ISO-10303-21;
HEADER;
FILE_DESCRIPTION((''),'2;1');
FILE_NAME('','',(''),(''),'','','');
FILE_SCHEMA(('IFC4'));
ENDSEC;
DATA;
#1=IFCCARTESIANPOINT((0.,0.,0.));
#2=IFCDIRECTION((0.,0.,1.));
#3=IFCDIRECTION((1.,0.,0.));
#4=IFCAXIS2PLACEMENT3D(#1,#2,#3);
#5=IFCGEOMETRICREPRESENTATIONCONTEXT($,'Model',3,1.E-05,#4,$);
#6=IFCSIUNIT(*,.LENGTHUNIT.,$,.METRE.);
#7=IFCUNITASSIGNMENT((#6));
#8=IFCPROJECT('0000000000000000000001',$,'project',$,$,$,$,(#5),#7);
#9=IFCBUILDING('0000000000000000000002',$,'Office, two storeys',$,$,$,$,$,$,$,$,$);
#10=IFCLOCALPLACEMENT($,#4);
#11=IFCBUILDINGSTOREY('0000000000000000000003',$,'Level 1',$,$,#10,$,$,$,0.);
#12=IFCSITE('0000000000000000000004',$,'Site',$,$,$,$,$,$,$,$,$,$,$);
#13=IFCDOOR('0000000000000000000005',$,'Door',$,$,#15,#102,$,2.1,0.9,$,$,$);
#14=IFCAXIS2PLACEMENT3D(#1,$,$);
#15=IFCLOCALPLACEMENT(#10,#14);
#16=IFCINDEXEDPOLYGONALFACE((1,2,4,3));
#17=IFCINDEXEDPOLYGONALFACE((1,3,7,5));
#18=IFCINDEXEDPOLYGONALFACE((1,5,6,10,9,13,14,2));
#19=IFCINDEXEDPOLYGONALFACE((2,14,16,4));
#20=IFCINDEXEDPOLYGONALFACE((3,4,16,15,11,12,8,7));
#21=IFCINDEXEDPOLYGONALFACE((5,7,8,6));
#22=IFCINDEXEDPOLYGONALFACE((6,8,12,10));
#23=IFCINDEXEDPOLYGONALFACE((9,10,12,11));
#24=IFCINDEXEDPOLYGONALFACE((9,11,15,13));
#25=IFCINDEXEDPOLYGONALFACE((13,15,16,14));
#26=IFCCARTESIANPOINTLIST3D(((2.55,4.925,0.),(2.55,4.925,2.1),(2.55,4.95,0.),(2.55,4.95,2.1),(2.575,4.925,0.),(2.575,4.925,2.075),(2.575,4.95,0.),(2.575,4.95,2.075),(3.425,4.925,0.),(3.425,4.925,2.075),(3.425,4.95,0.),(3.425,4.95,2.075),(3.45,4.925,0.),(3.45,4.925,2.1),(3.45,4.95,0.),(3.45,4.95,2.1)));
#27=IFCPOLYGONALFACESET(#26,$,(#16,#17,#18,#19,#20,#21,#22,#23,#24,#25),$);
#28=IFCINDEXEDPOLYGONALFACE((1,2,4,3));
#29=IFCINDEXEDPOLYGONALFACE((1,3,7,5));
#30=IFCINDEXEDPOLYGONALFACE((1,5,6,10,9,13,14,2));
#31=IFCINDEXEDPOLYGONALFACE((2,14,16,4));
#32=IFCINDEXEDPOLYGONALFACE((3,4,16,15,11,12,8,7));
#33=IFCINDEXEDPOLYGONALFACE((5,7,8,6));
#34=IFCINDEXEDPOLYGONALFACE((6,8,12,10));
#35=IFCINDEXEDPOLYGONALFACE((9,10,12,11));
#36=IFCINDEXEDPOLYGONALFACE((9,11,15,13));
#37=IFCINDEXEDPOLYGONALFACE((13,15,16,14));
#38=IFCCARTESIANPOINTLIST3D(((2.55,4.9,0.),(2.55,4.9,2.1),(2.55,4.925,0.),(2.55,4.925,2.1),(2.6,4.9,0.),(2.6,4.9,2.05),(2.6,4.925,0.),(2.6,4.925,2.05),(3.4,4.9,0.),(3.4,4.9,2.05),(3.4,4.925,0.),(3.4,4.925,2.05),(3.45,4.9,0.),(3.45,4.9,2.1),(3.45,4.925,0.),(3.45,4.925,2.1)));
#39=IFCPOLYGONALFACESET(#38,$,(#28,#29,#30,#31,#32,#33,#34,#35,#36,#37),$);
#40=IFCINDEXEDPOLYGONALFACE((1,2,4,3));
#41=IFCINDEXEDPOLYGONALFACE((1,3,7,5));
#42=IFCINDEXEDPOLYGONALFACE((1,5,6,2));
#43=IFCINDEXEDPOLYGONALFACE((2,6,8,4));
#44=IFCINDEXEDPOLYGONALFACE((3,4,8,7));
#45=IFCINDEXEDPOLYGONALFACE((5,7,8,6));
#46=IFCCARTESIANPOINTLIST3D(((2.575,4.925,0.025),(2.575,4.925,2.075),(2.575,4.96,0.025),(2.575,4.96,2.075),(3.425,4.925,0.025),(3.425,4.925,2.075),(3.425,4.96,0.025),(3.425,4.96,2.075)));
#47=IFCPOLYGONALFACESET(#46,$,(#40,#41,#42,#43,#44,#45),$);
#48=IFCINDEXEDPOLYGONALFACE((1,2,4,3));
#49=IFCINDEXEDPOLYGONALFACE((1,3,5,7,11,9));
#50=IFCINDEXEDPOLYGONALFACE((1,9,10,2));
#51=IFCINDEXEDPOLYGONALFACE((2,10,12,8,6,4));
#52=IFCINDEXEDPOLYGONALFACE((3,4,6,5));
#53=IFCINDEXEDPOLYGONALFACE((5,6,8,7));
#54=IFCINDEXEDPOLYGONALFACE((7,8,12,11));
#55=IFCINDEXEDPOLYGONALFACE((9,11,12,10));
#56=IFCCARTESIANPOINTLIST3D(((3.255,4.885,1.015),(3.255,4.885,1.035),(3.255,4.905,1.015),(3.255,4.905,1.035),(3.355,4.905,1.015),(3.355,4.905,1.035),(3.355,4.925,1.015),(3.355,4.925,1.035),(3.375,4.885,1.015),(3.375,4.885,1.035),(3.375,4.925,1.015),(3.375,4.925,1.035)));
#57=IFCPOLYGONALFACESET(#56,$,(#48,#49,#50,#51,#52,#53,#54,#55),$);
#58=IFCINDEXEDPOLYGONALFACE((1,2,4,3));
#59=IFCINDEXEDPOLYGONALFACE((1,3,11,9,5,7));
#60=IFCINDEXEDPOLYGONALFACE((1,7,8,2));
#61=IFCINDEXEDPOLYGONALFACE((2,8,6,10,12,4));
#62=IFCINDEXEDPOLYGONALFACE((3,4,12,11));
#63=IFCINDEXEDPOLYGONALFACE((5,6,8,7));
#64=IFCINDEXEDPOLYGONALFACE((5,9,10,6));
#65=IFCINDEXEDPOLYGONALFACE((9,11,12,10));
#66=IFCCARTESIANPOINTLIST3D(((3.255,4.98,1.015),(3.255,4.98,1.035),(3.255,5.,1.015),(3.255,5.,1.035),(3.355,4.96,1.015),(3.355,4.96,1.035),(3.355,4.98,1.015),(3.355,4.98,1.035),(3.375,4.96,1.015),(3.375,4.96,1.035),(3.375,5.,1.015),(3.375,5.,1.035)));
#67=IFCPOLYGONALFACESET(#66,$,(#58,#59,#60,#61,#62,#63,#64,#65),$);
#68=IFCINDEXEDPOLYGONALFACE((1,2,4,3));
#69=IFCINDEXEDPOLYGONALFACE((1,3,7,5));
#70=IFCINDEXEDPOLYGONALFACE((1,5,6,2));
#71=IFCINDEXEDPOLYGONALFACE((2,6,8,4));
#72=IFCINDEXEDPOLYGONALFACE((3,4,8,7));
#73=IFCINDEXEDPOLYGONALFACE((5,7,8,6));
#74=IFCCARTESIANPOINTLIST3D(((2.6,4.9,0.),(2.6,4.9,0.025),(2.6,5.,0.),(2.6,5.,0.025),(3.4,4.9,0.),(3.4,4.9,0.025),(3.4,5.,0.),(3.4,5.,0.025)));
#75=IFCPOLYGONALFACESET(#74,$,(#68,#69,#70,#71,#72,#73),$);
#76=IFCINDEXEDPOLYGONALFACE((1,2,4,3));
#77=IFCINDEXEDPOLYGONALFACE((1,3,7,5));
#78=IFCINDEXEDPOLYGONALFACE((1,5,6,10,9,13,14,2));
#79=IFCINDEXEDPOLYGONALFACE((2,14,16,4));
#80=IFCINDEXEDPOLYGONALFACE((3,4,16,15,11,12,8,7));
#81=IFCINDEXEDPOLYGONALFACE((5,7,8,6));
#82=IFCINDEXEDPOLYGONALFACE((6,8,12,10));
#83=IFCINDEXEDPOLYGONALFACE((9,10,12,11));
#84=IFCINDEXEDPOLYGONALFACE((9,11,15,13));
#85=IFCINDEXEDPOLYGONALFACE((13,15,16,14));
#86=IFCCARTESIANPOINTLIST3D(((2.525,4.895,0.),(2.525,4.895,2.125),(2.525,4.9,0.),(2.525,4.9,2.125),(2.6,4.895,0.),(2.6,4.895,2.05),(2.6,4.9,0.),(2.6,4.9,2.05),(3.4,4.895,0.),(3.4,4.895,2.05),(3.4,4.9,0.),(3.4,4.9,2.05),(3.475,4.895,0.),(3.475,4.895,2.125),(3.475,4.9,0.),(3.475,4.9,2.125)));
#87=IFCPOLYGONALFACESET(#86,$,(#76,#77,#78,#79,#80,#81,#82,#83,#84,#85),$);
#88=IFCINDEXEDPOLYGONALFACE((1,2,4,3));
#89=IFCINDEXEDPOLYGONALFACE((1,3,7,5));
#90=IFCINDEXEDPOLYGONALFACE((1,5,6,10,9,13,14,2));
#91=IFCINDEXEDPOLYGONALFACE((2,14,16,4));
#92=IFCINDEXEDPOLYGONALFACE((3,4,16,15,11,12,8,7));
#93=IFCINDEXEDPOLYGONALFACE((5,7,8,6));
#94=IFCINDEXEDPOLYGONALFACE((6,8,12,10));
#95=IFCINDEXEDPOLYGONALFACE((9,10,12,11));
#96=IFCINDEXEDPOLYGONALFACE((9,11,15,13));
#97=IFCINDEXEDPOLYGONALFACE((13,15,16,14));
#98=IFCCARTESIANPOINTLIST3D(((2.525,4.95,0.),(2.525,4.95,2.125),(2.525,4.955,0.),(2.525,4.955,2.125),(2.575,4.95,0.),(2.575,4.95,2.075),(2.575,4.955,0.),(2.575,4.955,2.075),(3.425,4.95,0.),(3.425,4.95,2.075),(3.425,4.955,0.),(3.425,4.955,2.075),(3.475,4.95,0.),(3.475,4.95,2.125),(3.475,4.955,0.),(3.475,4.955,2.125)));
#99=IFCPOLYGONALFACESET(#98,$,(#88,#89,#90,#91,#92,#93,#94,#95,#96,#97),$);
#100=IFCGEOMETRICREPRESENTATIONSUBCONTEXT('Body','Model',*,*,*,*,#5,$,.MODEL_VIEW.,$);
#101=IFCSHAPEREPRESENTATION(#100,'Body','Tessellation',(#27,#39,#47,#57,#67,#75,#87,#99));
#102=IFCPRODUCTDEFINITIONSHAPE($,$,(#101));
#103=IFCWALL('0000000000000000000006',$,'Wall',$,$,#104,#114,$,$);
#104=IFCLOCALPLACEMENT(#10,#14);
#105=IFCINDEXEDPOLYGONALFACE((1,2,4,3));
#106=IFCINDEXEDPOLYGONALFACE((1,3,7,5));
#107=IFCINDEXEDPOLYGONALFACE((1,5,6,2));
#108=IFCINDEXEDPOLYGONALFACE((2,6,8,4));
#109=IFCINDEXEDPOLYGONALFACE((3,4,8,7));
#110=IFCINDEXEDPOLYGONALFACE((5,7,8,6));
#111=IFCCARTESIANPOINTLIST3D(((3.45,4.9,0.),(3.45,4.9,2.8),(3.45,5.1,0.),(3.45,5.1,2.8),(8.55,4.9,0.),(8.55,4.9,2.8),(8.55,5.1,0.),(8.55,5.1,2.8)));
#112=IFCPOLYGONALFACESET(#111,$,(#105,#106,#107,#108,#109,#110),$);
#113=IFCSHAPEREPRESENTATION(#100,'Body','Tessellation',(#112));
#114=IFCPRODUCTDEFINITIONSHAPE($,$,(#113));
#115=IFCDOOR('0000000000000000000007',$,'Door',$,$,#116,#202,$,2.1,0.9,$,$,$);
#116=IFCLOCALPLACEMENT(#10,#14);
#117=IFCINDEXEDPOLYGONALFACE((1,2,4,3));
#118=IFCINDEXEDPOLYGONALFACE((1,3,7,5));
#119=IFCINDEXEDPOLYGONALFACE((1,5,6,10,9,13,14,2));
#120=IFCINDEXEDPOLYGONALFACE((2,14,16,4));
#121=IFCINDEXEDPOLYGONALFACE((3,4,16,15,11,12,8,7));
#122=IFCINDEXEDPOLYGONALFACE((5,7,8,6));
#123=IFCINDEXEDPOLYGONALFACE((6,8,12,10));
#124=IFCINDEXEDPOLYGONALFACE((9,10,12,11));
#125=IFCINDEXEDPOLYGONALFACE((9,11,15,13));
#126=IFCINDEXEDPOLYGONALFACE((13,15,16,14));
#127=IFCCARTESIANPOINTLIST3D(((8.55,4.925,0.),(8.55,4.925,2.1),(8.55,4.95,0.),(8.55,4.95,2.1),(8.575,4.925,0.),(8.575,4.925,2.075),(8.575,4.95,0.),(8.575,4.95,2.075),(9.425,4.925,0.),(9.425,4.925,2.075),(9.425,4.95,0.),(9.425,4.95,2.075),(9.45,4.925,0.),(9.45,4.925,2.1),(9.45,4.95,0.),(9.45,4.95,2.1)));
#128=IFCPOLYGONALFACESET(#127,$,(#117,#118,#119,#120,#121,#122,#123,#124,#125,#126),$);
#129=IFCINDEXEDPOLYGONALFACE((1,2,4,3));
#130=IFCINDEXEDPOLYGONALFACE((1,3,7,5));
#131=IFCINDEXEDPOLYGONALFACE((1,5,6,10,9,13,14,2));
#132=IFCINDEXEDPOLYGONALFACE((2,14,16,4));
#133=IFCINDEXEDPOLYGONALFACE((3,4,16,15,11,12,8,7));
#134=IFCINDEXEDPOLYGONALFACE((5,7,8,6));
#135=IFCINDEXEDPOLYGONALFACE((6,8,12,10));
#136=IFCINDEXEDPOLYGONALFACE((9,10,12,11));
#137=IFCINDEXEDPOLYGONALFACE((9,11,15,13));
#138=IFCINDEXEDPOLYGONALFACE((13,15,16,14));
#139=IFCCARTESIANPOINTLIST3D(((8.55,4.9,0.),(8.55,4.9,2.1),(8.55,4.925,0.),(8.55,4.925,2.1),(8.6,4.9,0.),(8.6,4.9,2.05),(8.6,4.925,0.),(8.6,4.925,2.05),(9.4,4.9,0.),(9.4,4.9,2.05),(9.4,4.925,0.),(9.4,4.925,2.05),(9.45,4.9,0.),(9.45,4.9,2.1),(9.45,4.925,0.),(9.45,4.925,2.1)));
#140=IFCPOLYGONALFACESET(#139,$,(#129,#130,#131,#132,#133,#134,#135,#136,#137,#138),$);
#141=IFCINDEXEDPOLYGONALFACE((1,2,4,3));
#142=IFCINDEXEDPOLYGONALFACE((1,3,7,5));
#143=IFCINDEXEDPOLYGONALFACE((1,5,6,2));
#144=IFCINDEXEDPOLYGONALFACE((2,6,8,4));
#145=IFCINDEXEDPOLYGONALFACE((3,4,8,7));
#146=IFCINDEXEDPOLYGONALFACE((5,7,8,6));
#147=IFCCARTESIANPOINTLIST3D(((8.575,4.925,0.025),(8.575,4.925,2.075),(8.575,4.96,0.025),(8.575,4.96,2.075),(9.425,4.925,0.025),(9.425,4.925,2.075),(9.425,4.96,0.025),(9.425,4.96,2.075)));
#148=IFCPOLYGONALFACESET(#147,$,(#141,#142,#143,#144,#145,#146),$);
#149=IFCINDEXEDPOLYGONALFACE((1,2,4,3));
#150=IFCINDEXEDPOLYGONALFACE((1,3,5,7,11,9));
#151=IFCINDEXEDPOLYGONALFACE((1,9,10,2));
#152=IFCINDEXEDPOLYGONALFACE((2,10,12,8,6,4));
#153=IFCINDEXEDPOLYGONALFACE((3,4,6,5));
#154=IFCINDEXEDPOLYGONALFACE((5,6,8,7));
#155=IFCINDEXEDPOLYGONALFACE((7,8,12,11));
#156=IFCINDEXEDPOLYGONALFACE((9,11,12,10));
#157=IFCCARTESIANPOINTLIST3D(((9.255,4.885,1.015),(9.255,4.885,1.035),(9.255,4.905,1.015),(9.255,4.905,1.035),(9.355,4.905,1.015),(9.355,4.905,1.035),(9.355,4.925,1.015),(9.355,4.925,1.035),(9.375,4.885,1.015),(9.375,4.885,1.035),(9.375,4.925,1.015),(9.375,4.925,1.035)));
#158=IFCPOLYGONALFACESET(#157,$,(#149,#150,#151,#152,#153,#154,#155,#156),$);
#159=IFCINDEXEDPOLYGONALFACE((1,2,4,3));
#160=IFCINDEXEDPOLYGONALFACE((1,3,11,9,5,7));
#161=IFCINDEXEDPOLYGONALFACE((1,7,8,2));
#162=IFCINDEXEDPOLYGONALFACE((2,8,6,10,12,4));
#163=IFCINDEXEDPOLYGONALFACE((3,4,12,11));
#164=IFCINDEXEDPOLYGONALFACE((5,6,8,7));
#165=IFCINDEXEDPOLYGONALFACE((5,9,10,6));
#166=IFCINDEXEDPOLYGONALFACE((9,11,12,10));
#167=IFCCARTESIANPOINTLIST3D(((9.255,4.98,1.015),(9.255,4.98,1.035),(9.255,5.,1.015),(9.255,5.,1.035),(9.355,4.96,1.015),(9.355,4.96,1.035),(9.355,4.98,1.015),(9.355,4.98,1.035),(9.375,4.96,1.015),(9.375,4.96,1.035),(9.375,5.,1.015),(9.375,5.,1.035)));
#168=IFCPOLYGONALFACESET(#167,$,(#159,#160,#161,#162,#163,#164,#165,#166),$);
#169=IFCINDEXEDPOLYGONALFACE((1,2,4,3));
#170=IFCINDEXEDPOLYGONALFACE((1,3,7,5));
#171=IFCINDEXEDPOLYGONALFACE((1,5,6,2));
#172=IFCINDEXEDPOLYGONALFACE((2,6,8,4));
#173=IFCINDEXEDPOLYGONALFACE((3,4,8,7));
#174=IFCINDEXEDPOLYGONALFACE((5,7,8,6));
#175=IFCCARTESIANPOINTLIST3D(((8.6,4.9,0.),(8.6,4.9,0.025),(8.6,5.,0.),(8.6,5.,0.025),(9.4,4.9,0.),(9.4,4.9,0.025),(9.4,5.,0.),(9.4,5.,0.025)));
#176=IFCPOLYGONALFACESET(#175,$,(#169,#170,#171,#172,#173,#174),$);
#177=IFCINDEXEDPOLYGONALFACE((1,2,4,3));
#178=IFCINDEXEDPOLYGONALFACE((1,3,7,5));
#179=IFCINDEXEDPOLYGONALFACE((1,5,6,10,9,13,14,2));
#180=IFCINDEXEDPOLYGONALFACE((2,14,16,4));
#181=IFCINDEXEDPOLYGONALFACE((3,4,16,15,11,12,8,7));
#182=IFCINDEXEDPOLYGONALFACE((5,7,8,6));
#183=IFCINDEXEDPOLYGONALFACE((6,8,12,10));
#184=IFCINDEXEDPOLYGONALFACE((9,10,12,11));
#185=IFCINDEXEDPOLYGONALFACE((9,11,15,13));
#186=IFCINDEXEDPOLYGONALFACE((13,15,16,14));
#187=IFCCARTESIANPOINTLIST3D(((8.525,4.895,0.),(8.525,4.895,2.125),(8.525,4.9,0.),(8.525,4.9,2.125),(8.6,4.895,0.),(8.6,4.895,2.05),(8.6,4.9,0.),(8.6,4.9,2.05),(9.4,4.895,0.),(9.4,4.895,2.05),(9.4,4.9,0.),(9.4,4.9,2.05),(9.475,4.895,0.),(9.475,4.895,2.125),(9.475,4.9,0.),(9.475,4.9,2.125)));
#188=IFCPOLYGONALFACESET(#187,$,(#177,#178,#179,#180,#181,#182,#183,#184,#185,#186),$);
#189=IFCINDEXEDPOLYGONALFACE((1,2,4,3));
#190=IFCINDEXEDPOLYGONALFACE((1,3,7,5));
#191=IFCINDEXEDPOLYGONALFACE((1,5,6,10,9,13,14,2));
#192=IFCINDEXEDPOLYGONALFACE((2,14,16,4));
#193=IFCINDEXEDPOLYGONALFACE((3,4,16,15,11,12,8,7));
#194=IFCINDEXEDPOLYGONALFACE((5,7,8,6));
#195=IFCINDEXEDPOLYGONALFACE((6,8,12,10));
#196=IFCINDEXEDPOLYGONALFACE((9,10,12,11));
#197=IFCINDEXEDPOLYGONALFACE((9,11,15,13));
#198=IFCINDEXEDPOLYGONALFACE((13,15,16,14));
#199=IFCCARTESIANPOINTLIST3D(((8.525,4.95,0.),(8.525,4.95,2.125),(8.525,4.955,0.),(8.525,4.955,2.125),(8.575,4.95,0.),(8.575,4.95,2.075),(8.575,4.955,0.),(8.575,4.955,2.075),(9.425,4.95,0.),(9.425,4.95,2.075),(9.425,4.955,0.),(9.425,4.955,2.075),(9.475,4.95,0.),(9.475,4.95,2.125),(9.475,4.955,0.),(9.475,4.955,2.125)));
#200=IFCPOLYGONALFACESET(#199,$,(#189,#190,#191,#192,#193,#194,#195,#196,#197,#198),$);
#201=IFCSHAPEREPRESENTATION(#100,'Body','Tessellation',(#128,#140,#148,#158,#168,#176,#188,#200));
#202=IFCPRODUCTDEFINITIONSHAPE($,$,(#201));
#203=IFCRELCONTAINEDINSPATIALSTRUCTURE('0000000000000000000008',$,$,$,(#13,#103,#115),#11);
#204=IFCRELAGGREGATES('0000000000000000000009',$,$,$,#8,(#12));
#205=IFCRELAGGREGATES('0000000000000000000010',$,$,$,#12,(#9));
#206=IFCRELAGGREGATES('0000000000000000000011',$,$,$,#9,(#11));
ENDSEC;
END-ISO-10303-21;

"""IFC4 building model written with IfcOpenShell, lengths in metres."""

from ifc_helpers import new_model, si_unit, frame, origin_with_axes, place, context, subcontext, project, spatial, line, indexed_curve, outline, extrude, element, save


model = new_model("IFC4")

# Units and contexts
model_context = context("Model", 3, precision=1e-05, world=origin_with_axes())
body_context = subcontext(model_context, "Body", "Model", "MODEL_VIEW")
ifc_project = project(units=[si_unit("LENGTHUNIT", "METRE")], contexts=[model_context])

# Site, building, storey
site = spatial("IfcSite", under=ifc_project, Name="Site")
building = spatial("IfcBuilding", under=site, Name="Office, two storeys")
storey_placement = place(None, origin_with_axes())
storey = spatial("IfcBuildingStorey", under=building, at=storey_placement, Name="Level 1", Elevation=0.0)

# Door
door_1_placement = place(storey_placement, frame((2.55, 4.9, 0.0), z_axis=(0.0, 0.0, 1.0), x_axis=(1.0, 0.0, 0.0)))
element("IfcDoor", 1, at=door_1_placement, inside=storey, Name="Door", OverallHeight=2.1, OverallWidth=0.9, context=body_context, shape_type="SweptSolid", body=[
    extrude(outline(indexed_curve([(0.0, 0.0), (0.0, 2.1), (0.9, 2.1), (0.9, 0.0), (0.875, 0.0), (0.875, 2.075), (0.025, 2.075), (0.025, 0.0)], segments=[line(1, 2, 3, 4, 5, 6, 7, 8, 1)])), frame((0.0, 0.025, 0.0), z_axis=(0.0, -1.0, 0.0), x_axis=(1.0, 0.0, 0.0)), (0.0, 0.0, -1.0), 0.025),
    extrude(outline(indexed_curve([(0.0, 0.0), (0.0, 2.1), (0.9, 2.1), (0.9, 0.0), (0.85, 0.0), (0.85, 2.05), (0.05, 2.05), (0.05, 0.0)], segments=[line(1, 2, 3, 4, 5, 6, 7, 8, 1)])), frame((0.0, 0.0, 0.0), z_axis=(0.0, -1.0, 0.0), x_axis=(1.0, 0.0, 0.0)), (0.0, 0.0, -1.0), 0.025),
    extrude(outline(indexed_curve([(0.0, 0.0), (0.85, 0.0), (0.85, 0.035), (0.0, 0.035)], segments=[line(1, 2, 3, 4, 1)])), frame((0.025, 0.025, 0.025), z_axis=(0.0, 0.0, 1.0), x_axis=(1.0, 0.0, 0.0)), (0.0, 0.0, 1.0), 2.05),
    extrude(outline(indexed_curve([(0.0, 0.0), (0.0, -0.04), (-0.12, -0.04), (-0.12, -0.02), (-0.02, -0.02), (-0.02, 0.0)], segments=[line(1, 2, 3, 4, 5, 6, 1)])), frame((0.825, 0.025, 1.015), z_axis=(0.0, 0.0, 1.0), x_axis=(1.0, 0.0, 0.0)), (0.0, 0.0, 1.0), 0.02),
    extrude(outline(indexed_curve([(0.0, 0.0), (0.0, 0.04), (-0.12, 0.04), (-0.12, 0.02), (-0.02, 0.02), (-0.02, 0.0)], segments=[line(1, 2, 3, 4, 5, 6, 1)])), frame((0.825, 0.06, 1.015), z_axis=(0.0, 0.0, 1.0), x_axis=(1.0, 0.0, 0.0)), (0.0, 0.0, 1.0), 0.02),
    extrude(outline(indexed_curve([(0.0, 0.0), (0.8, 0.0), (0.8, 0.1), (0.0, 0.1)], segments=[line(1, 2, 3, 4, 1)])), frame((0.05, 0.0, 0.0), z_axis=(0.0, 0.0, 1.0), x_axis=(1.0, 0.0, 0.0)), (0.0, 0.0, 1.0), 0.025),
    extrude(outline(indexed_curve([(0.0, 0.0), (0.0, 2.125), (0.95, 2.125), (0.95, 0.0), (0.875, 0.0), (0.875, 2.05), (0.075, 2.05), (0.075, 0.0)], segments=[line(1, 2, 3, 4, 5, 6, 7, 8, 1)])), frame((-0.025, -0.005, 0.0), z_axis=(0.0, -1.0, 0.0), x_axis=(1.0, 0.0, 0.0)), (0.0, 0.0, -1.0), 0.005),
    extrude(outline(indexed_curve([(0.0, 0.0), (0.0, 2.125), (0.95, 2.125), (0.95, 0.0), (0.9, 0.0), (0.9, 2.075), (0.05, 2.075), (0.05, 0.0)], segments=[line(1, 2, 3, 4, 5, 6, 7, 8, 1)])), frame((-0.025, 0.05, 0.0), z_axis=(0.0, -1.0, 0.0), x_axis=(1.0, 0.0, 0.0)), (0.0, 0.0, -1.0), 0.005),
])

# Wall
wall_1_placement = place(storey_placement, frame((3.45, 5.0, 0.0), z_axis=(0.0, 0.0, 1.0), x_axis=(1.0, 0.0, 0.0)))
element("IfcWall", 2, at=wall_1_placement, inside=storey, Name="Wall", context=body_context, shape_type="SweptSolid", body=[
    extrude(outline(indexed_curve([(0.0, 0.0), (0.0, 0.2), (5.1, 0.2), (5.1, 0.0), (0.0, 0.0)], self_intersect=False)), frame((0.0, -0.1, 0.0), z_axis=(0.0, 0.0, 1.0), x_axis=(1.0, 0.0, 0.0)), (0.0, 0.0, 1.0), 2.8),
])

# Door
door_2_placement = place(storey_placement, frame((8.55, 4.9, 0.0), z_axis=(0.0, 0.0, 1.0), x_axis=(1.0, 0.0, 0.0)))
element("IfcDoor", 3, at=door_2_placement, inside=storey, Name="Door", OverallHeight=2.1, OverallWidth=0.9, context=body_context, shape_type="SweptSolid", body=[
    extrude(outline(indexed_curve([(0.0, 0.0), (0.0, 2.1), (0.9, 2.1), (0.9, 0.0), (0.875, 0.0), (0.875, 2.075), (0.025, 2.075), (0.025, 0.0)], segments=[line(1, 2, 3, 4, 5, 6, 7, 8, 1)])), frame((0.0, 0.025, 0.0), z_axis=(0.0, -1.0, 0.0), x_axis=(1.0, 0.0, 0.0)), (0.0, 0.0, -1.0), 0.025),
    extrude(outline(indexed_curve([(0.0, 0.0), (0.0, 2.1), (0.9, 2.1), (0.9, 0.0), (0.85, 0.0), (0.85, 2.05), (0.05, 2.05), (0.05, 0.0)], segments=[line(1, 2, 3, 4, 5, 6, 7, 8, 1)])), frame((0.0, 0.0, 0.0), z_axis=(0.0, -1.0, 0.0), x_axis=(1.0, 0.0, 0.0)), (0.0, 0.0, -1.0), 0.025),
    extrude(outline(indexed_curve([(0.0, 0.0), (0.85, 0.0), (0.85, 0.035), (0.0, 0.035)], segments=[line(1, 2, 3, 4, 1)])), frame((0.025, 0.025, 0.025), z_axis=(0.0, 0.0, 1.0), x_axis=(1.0, 0.0, 0.0)), (0.0, 0.0, 1.0), 2.05),
    extrude(outline(indexed_curve([(0.0, 0.0), (0.0, -0.04), (-0.12, -0.04), (-0.12, -0.02), (-0.02, -0.02), (-0.02, 0.0)], segments=[line(1, 2, 3, 4, 5, 6, 1)])), frame((0.825, 0.025, 1.015), z_axis=(0.0, 0.0, 1.0), x_axis=(1.0, 0.0, 0.0)), (0.0, 0.0, 1.0), 0.02),
    extrude(outline(indexed_curve([(0.0, 0.0), (0.0, 0.04), (-0.12, 0.04), (-0.12, 0.02), (-0.02, 0.02), (-0.02, 0.0)], segments=[line(1, 2, 3, 4, 5, 6, 1)])), frame((0.825, 0.06, 1.015), z_axis=(0.0, 0.0, 1.0), x_axis=(1.0, 0.0, 0.0)), (0.0, 0.0, 1.0), 0.02),
    extrude(outline(indexed_curve([(0.0, 0.0), (0.8, 0.0), (0.8, 0.1), (0.0, 0.1)], segments=[line(1, 2, 3, 4, 1)])), frame((0.05, 0.0, 0.0), z_axis=(0.0, 0.0, 1.0), x_axis=(1.0, 0.0, 0.0)), (0.0, 0.0, 1.0), 0.025),
    extrude(outline(indexed_curve([(0.0, 0.0), (0.0, 2.125), (0.95, 2.125), (0.95, 0.0), (0.875, 0.0), (0.875, 2.05), (0.075, 2.05), (0.075, 0.0)], segments=[line(1, 2, 3, 4, 5, 6, 7, 8, 1)])), frame((-0.025, -0.005, 0.0), z_axis=(0.0, -1.0, 0.0), x_axis=(1.0, 0.0, 0.0)), (0.0, 0.0, -1.0), 0.005),
    extrude(outline(indexed_curve([(0.0, 0.0), (0.0, 2.125), (0.95, 2.125), (0.95, 0.0), (0.9, 0.0), (0.9, 2.075), (0.05, 2.075), (0.05, 0.0)], segments=[line(1, 2, 3, 4, 5, 6, 7, 8, 1)])), frame((-0.025, 0.05, 0.0), z_axis=(0.0, -1.0, 0.0), x_axis=(1.0, 0.0, 0.0)), (0.0, 0.0, -1.0), 0.005),
])

save(model, "model.ifc")
